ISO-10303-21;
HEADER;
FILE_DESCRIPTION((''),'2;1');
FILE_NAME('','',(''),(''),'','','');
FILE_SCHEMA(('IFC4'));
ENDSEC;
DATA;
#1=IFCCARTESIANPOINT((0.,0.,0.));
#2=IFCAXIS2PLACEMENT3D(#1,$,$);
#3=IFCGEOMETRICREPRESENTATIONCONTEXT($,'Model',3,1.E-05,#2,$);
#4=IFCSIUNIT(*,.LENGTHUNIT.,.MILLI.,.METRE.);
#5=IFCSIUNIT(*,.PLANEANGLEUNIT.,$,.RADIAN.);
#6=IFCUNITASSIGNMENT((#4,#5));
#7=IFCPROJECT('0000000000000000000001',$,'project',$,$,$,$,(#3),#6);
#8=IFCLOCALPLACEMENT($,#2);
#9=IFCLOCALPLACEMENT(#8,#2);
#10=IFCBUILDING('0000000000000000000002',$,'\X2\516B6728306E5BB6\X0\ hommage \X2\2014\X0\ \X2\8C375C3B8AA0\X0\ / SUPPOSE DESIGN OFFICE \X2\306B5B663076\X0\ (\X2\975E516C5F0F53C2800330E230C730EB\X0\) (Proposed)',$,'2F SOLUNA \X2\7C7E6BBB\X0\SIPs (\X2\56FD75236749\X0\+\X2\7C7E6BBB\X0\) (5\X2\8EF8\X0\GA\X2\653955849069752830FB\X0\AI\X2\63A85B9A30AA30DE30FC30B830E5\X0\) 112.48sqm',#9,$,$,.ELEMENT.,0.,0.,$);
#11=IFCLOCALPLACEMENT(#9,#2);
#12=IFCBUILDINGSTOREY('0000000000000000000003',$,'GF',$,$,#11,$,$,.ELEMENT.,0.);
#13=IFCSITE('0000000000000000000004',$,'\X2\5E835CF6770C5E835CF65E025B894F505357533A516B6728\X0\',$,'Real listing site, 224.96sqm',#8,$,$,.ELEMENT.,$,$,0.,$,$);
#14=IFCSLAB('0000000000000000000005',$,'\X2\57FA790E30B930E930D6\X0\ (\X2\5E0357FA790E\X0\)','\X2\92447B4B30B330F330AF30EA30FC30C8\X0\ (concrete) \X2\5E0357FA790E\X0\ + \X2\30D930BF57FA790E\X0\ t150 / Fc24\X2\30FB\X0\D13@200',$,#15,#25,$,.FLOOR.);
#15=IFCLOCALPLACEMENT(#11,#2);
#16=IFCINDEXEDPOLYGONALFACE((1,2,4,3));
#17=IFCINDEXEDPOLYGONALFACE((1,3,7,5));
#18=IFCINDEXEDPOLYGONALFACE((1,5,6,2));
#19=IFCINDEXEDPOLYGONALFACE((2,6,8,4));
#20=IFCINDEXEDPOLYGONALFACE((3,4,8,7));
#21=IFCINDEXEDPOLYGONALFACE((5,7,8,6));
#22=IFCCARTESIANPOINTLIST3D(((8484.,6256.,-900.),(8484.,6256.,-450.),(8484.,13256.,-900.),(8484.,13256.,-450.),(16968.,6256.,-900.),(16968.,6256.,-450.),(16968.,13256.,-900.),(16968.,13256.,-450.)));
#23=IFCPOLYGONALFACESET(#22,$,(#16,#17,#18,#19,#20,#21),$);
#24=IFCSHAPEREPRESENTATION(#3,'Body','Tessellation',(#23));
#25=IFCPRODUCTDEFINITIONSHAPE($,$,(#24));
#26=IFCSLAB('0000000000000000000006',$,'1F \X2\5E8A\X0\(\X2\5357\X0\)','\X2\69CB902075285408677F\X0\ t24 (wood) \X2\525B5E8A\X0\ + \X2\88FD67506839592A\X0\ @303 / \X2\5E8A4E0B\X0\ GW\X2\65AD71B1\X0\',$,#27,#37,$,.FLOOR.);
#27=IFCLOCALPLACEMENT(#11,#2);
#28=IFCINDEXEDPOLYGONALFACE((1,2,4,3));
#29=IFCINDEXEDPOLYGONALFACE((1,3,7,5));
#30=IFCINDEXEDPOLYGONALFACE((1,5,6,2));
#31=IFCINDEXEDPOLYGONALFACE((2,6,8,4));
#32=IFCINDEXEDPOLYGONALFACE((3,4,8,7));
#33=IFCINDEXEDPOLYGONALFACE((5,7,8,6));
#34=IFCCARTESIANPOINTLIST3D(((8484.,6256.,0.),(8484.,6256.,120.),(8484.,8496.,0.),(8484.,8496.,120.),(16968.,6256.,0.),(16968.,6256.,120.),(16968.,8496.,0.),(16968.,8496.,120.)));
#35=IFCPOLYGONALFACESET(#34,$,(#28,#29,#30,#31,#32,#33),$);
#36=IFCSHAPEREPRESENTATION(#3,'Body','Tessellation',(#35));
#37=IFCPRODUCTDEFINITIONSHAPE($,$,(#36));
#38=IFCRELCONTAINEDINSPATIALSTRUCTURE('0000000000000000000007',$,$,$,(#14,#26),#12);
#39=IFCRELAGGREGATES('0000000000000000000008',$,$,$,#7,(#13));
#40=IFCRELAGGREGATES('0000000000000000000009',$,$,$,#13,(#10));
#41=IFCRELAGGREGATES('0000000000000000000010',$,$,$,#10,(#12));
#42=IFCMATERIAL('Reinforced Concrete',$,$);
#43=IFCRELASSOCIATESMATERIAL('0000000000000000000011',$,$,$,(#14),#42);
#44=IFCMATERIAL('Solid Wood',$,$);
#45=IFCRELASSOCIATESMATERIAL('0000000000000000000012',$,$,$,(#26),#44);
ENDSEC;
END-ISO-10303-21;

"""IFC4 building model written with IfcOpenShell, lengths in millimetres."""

from ifc_helpers import new_model, si_unit, frame, frame_2d, origin, place, context, project, spatial, rectangle, extrude, material, element, save


model = new_model("IFC4")

# Units and contexts
model_context = context("Model", 3, precision=1e-05, world=origin())
ifc_project = project(units=[si_unit("LENGTHUNIT", "METRE", prefix="MILLI"), si_unit("PLANEANGLEUNIT", "RADIAN")], contexts=[model_context])

# Site, building, storey
site_placement = place(None, origin())
site = spatial("IfcSite", under=ifc_project, at=site_placement, Name="広島県広島市安佐南区八木", ObjectType="Real listing site, 224.96sqm", CompositionType="ELEMENT", RefElevation=0.0)
building_placement = place(site_placement, origin())
building = spatial("IfcBuilding", under=site, at=building_placement, Name="八木の家 hommage — 谷尻誠 / SUPPOSE DESIGN OFFICE に学ぶ (非公式参考モデル) (Proposed)", ObjectType="2F SOLUNA 籾殻SIPs (国産杉+籾殻) (5軸GA改善適用・AI推定オマージュ) 112.48sqm", CompositionType="ELEMENT", ElevationOfRefHeight=0.0, ElevationOfTerrain=0.0)
storey_placement = place(building_placement, origin())
storey = spatial("IfcBuildingStorey", under=building, at=storey_placement, Name="GF", CompositionType="ELEMENT", Elevation=0.0)

# Slabs
ifc_material_1 = material(Name="Reinforced Concrete")
slab_1_placement = place(storey_placement, frame((4242.0, 3128.0, -450.0)))
element("IfcSlab", 1, at=slab_1_placement, inside=storey, material=ifc_material_1, Name="基礎スラブ (布基礎)", Description="鉄筋コンクリート (concrete) 布基礎 + ベタ基礎 t150 / Fc24・D13@200", PredefinedType="FLOOR", context=model_context, shape_type="SweptSolid", body=[
    extrude(rectangle(XDim=8484.0, YDim=7000.0, at=frame_2d((4242.0, 3500.0))), frame((4242.0, 3128.0, -450.0)), (0.0, 0.0, 1.0), 450.0),
])
ifc_material_2 = material(Name="Solid Wood")
slab_2_placement = place(storey_placement, frame((4242.0, 3128.0, 0.0)))
element("IfcSlab", 2, at=slab_2_placement, inside=storey, material=ifc_material_2, Name="1F 床(南)", Description="構造用合板 t24 (wood) 剛床 + 製材根太 @303 / 床下 GW断熱", PredefinedType="FLOOR", context=model_context, shape_type="SweptSolid", body=[
    extrude(rectangle(XDim=8484.0, YDim=2240.0, at=frame_2d((4242.0, 1120.0))), frame((4242.0, 3128.0, 0.0)), (0.0, 0.0, 1.0), 120.0),
])

save(model, "model.ifc")
